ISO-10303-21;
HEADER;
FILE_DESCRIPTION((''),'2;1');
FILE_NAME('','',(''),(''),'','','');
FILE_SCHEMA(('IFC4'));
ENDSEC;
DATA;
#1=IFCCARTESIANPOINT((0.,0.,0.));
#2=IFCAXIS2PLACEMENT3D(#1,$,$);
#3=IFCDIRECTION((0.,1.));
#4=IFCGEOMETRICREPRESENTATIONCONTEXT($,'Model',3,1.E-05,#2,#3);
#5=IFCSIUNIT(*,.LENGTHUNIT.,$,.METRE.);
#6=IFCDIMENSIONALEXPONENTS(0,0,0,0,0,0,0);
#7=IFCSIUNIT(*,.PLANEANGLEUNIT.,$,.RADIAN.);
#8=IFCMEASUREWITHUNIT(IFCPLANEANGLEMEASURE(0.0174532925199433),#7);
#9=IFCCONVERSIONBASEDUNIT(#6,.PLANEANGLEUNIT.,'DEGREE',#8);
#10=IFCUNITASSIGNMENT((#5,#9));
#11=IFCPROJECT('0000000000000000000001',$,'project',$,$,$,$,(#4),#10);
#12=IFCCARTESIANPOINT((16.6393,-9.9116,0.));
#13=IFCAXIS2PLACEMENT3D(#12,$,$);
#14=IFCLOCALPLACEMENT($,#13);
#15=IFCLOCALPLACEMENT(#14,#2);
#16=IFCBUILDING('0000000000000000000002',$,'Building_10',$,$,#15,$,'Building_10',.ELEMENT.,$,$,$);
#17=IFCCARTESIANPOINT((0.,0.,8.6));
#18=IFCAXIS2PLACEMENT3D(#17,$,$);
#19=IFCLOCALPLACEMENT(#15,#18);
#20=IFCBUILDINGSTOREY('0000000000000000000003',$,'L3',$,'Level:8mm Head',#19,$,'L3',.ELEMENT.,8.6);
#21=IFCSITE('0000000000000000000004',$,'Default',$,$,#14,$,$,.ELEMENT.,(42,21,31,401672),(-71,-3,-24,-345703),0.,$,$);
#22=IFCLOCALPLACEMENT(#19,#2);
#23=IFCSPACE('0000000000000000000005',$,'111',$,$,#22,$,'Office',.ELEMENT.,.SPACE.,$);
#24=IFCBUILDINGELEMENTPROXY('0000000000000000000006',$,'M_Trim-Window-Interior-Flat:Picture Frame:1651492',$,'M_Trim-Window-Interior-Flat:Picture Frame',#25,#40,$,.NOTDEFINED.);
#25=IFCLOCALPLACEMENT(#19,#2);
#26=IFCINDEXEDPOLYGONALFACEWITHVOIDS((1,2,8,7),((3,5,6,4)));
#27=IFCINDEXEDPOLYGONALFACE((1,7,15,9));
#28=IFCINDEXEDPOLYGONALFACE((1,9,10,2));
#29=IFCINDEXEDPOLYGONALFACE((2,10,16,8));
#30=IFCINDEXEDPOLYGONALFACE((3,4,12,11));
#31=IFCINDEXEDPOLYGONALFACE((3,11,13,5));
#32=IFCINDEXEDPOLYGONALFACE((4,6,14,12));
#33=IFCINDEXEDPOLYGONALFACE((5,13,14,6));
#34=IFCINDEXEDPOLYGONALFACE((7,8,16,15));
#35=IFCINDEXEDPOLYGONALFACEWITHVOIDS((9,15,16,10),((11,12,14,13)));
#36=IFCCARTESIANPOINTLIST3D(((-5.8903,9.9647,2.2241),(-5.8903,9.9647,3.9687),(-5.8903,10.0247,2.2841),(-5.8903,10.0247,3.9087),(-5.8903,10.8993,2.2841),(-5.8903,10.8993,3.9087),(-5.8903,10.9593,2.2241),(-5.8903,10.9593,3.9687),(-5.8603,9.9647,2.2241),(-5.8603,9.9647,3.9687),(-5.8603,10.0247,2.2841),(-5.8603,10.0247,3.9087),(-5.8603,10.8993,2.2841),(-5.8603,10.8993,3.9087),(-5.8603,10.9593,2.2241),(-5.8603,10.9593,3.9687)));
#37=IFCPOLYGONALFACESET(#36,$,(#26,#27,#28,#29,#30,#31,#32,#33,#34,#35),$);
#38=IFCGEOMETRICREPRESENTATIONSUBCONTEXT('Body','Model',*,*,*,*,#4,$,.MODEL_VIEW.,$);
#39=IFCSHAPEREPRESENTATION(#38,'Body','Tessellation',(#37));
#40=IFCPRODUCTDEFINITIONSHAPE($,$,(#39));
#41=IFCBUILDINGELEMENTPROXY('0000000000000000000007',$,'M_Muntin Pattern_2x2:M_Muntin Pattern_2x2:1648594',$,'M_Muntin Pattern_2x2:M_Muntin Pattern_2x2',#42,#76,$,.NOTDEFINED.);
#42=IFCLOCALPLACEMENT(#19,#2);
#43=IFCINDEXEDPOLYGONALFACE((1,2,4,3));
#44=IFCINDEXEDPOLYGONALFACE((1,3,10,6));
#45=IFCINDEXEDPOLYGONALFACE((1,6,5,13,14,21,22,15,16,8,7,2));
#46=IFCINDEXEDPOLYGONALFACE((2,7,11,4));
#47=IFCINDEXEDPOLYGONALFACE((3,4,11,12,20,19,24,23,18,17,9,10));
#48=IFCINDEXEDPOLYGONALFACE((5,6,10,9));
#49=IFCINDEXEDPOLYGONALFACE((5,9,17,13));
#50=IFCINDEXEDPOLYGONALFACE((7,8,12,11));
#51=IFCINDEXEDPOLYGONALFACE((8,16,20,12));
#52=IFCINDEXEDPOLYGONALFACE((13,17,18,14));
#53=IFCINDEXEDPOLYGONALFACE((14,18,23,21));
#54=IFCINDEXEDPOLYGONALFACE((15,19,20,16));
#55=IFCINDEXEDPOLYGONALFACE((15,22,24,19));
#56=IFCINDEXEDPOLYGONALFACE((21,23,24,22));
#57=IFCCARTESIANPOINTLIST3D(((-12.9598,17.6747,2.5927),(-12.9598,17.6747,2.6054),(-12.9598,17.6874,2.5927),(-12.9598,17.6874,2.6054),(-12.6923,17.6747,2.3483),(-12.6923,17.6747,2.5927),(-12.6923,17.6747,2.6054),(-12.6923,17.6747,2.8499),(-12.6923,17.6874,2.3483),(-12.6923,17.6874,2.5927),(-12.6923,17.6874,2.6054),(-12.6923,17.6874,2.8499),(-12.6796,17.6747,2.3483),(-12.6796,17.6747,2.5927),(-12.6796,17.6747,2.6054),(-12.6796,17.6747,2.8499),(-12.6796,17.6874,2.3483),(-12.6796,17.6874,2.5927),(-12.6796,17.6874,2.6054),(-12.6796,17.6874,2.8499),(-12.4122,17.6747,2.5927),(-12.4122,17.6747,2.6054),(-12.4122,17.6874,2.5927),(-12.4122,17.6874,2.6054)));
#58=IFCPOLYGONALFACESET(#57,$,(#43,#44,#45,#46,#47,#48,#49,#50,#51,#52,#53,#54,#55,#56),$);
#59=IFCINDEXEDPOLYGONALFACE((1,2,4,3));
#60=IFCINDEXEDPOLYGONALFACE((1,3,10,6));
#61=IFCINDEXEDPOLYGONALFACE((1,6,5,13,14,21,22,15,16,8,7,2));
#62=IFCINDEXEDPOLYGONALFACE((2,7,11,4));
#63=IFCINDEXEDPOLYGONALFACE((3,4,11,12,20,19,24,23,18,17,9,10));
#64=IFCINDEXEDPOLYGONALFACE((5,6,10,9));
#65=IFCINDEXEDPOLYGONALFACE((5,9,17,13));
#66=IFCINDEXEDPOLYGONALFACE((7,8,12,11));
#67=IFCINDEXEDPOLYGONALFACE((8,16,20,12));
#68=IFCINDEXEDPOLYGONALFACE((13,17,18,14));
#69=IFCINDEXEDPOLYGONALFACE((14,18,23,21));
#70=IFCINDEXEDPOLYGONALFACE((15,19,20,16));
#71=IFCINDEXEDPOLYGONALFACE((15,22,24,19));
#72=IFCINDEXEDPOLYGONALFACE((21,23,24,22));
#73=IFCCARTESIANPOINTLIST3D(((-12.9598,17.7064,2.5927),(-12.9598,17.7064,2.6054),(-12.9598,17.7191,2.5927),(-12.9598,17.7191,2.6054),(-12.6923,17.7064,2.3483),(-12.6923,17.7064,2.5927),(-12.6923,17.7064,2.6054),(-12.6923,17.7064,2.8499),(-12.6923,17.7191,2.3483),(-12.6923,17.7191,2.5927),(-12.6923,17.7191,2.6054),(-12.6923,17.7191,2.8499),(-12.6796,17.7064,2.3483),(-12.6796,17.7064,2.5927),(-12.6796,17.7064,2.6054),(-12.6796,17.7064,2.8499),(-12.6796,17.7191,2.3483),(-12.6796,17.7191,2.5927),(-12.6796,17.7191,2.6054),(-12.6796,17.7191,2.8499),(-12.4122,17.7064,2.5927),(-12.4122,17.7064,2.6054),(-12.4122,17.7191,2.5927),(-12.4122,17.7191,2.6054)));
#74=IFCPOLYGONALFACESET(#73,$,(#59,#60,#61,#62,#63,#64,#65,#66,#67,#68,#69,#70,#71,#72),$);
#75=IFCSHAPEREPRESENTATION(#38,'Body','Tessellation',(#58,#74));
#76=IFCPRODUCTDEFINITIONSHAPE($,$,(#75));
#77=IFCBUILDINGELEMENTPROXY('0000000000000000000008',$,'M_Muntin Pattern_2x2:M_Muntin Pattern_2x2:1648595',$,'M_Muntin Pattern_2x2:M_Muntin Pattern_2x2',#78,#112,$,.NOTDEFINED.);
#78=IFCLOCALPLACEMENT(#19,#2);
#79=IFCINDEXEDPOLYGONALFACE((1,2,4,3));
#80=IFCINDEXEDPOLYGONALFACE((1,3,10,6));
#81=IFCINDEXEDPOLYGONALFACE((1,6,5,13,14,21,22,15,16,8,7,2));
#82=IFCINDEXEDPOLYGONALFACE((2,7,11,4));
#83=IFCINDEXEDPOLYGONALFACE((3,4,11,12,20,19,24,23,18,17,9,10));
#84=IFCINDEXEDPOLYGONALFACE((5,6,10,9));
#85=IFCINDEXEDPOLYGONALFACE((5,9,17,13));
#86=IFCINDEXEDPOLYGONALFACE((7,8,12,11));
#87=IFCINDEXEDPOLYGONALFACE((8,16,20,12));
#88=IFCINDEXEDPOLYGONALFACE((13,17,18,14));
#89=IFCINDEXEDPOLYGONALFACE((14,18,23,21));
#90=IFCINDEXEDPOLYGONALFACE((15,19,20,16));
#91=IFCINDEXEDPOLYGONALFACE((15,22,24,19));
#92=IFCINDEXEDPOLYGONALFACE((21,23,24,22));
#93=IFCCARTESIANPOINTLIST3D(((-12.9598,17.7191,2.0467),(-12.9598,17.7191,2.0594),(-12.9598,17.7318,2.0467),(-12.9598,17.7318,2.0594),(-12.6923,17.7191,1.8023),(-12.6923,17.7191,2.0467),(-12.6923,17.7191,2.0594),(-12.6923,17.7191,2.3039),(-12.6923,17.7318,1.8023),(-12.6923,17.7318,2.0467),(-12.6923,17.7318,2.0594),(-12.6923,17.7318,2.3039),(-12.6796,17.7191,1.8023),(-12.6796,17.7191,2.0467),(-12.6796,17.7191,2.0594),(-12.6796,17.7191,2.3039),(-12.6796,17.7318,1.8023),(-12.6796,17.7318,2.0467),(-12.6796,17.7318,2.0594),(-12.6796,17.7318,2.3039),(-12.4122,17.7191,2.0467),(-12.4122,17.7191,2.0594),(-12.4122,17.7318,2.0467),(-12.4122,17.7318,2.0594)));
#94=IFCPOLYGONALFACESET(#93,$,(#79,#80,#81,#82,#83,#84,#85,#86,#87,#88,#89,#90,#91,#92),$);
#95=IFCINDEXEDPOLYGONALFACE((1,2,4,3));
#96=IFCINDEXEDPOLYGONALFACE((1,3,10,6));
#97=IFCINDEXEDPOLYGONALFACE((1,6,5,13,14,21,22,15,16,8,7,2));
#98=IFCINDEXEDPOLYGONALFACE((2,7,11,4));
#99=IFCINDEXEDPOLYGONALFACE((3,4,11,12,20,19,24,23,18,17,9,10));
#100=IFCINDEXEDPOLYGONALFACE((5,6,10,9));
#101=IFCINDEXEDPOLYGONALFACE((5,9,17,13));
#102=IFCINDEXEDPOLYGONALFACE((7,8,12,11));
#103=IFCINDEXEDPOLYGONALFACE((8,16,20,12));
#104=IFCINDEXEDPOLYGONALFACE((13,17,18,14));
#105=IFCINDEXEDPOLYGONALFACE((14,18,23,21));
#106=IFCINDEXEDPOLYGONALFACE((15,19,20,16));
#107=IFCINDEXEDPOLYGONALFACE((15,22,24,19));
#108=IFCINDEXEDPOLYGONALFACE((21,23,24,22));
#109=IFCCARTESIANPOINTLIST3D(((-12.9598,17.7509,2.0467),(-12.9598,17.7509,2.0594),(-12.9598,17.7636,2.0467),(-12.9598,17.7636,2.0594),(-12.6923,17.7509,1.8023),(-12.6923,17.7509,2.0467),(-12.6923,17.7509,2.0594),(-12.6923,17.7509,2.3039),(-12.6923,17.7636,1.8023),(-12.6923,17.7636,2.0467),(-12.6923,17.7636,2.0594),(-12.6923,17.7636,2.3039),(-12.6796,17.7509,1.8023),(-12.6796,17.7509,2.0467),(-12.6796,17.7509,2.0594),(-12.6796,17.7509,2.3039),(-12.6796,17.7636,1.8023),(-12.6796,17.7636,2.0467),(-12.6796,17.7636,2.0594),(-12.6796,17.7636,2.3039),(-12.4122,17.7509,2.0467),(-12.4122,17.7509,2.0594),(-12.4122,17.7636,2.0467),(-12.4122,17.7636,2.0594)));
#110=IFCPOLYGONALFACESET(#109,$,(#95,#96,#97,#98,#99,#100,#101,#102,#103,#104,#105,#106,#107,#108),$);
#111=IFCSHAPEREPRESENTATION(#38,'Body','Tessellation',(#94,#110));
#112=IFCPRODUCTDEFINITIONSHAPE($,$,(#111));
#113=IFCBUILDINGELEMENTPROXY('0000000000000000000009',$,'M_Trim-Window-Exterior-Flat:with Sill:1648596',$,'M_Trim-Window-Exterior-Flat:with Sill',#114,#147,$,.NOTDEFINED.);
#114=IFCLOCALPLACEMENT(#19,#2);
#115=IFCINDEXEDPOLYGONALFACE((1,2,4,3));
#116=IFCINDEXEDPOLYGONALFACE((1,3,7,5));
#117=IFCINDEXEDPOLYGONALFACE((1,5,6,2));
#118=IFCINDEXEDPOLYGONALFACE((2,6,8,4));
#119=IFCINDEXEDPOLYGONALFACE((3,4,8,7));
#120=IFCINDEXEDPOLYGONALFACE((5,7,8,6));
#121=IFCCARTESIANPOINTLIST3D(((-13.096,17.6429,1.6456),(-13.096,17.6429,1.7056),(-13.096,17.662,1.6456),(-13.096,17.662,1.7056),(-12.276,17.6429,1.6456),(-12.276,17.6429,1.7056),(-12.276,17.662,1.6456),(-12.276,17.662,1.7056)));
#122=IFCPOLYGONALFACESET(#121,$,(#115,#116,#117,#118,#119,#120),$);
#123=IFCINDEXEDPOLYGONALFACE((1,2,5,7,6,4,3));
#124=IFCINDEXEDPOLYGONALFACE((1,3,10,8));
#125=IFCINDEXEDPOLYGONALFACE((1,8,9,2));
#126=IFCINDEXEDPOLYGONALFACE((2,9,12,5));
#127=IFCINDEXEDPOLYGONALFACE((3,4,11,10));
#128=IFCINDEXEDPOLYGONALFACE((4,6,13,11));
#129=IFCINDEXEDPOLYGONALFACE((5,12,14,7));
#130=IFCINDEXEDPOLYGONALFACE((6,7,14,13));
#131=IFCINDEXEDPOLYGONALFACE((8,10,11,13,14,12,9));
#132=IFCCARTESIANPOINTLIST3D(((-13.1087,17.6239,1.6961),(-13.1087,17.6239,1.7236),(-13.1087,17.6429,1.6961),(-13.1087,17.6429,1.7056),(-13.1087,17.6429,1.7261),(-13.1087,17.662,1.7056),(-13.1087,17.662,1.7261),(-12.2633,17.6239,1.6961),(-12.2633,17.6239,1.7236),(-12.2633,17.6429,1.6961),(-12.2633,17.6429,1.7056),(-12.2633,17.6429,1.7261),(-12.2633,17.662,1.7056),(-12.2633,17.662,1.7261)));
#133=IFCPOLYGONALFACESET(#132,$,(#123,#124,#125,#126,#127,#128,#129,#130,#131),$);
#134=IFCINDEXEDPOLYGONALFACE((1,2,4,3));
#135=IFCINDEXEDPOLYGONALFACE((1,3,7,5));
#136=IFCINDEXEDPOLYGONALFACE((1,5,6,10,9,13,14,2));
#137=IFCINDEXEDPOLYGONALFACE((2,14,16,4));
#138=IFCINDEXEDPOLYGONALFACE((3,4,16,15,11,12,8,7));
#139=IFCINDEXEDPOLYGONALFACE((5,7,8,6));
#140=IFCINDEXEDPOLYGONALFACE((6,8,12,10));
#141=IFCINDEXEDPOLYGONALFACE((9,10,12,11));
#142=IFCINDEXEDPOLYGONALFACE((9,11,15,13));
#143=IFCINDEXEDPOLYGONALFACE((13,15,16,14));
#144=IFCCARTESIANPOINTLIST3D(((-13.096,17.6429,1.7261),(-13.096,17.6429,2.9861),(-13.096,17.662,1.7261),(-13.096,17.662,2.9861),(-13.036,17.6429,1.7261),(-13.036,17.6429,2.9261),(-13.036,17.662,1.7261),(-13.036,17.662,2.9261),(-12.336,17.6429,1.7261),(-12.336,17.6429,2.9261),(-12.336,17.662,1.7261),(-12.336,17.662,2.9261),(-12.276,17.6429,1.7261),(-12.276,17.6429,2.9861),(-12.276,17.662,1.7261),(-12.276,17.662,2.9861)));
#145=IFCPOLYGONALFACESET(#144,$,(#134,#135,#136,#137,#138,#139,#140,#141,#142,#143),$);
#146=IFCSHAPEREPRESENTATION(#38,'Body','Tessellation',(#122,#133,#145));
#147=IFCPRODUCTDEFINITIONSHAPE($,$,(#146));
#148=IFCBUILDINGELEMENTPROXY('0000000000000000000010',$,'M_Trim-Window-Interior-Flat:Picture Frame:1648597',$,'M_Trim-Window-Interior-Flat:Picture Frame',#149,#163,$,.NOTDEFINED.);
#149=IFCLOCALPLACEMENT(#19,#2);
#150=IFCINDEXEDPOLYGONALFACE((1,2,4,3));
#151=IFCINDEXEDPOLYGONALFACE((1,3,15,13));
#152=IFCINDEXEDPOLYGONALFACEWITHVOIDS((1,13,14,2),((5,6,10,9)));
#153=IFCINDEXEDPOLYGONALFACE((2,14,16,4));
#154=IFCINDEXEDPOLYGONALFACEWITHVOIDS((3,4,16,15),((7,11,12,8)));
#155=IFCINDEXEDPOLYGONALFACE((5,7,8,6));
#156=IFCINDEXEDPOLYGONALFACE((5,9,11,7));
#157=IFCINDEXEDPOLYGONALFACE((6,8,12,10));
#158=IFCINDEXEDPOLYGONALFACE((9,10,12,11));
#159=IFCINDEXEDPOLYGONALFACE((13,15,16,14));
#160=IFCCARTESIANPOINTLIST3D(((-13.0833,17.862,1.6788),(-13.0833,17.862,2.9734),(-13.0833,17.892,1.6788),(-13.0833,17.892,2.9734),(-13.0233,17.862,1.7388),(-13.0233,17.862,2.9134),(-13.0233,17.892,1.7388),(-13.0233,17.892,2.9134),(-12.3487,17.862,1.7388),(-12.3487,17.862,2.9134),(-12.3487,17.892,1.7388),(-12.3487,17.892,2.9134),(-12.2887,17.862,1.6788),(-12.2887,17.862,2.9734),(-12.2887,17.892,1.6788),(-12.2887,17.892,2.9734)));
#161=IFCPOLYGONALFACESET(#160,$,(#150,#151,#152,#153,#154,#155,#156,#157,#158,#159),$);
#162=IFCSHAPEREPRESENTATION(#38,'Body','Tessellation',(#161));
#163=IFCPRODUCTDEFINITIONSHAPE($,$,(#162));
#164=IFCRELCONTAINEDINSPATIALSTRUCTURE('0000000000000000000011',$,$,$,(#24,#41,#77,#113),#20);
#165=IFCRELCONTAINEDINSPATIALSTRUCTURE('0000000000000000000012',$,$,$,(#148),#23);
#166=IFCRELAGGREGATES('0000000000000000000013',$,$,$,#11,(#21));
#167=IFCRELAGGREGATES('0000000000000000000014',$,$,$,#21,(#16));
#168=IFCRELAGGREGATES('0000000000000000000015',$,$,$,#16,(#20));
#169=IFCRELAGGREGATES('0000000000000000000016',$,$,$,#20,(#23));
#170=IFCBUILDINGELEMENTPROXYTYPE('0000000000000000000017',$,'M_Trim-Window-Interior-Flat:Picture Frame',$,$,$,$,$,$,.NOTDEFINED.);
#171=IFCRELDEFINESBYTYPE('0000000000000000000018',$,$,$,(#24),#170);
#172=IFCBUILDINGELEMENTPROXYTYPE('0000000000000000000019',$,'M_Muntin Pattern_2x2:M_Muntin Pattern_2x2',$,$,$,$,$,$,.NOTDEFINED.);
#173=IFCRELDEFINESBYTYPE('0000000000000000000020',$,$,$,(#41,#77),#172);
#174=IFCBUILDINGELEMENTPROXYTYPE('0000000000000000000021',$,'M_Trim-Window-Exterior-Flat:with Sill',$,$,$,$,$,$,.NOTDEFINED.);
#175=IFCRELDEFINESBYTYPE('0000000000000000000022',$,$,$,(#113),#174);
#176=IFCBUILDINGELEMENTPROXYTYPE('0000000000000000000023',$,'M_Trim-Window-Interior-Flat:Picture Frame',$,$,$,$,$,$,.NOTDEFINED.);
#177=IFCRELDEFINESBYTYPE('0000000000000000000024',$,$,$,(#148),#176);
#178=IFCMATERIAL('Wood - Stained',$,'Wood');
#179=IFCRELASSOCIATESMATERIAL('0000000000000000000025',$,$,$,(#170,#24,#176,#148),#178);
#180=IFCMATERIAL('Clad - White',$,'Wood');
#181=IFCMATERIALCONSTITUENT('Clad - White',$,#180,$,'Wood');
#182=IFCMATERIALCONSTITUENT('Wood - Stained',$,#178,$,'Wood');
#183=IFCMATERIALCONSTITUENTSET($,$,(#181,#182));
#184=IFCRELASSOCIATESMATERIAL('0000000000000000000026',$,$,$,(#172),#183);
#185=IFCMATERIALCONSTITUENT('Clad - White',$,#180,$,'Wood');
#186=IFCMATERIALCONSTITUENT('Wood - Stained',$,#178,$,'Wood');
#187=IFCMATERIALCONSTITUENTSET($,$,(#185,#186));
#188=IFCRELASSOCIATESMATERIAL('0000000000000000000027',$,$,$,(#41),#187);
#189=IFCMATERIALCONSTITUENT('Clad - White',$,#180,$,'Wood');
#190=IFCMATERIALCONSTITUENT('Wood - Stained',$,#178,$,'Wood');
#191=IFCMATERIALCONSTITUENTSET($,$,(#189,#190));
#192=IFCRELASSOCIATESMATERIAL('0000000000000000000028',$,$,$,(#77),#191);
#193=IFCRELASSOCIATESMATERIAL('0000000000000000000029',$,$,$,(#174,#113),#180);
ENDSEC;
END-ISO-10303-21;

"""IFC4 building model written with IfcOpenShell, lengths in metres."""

from ifc_helpers import new_model, entity, si_unit, converted_unit, direction, frame, origin, place, context, subcontext, project, spatial, indexed_curve, outline, extrude, source, transform, mapped, material, constituent, constituent_set, type_object, type_shapes, element, save


model = new_model("IFC4")

# Units and contexts
model_context = context("Model", 3, precision=1e-05, world=origin(), true_north=direction((0.0, 1.0)))
body_context = subcontext(model_context, "Body", "Model", "MODEL_VIEW")
ifc_project = project(units=[si_unit("LENGTHUNIT", "METRE"), converted_unit("PLANEANGLEUNIT", "DEGREE", entity("IfcPlaneAngleMeasure", 0.0174532925199433), si_unit("PLANEANGLEUNIT", "RADIAN"), dimensions=[0, 0, 0, 0, 0, 0, 0])], contexts=[model_context])

# Site, building, storey
site_placement = place(None, frame((16.6393, -9.9116, 0.0)))
site = spatial("IfcSite", under=ifc_project, at=site_placement, Name="Default", CompositionType="ELEMENT", RefLatitude=(42, 21, 31, 401672), RefLongitude=(-71, -3, -24, -345703), RefElevation=0.0)
building_placement = place(site_placement, origin())
building = spatial("IfcBuilding", under=site, at=building_placement, Name="Building_10", LongName="Building_10", CompositionType="ELEMENT")
storey_placement = place(building_placement, frame((0.0, 0.0, 8.6)))
storey = spatial("IfcBuildingStorey", under=building, at=storey_placement, Name="L3", ObjectType="Level:8mm Head", LongName="L3", CompositionType="ELEMENT", Elevation=8.6)

# Building element proxies
ifc_material_1 = material(Name="Clad - White", Category="Wood")
ifc_material_2 = material(Name="Wood - Stained", Category="Wood")
building_element_proxy_type_1 = type_object("IfcBuildingElementProxyType", Name="M_Trim-Window-Interior-Flat:Picture Frame", PredefinedType="NOTDEFINED", material=ifc_material_2)
shared_shape_1 = source(origin(), body_context, "Body", "SweptSolid", [
    extrude(outline(indexed_curve([(-0.4973, -0.8723), (0.4973, -0.8723), (0.4973, 0.8723), (-0.4973, 0.8723), (-0.4973, -0.8723)], self_intersect=False), holes=[indexed_curve([(-0.4373, -0.8123), (-0.4373, 0.8123), (0.4373, 0.8123), (0.4373, -0.8123), (-0.4373, -0.8123)], self_intersect=False)]), frame((0.0, -0.825, 0.0), z_axis=(0.0, 0.0, 1.0), x_axis=(-1.0, 0.0, 0.0)), (0.0, 0.0, 1.0), 0.03),
])
type_shapes(building_element_proxy_type_1, [shared_shape_1])
for number, where, z_axis, x_axis, name in (
    (1, (-5.8603, 10.462, 3.9214), (-1.0, 0.0, 0.0), (0.0, -1.0, 0.0), "M_Trim-Window-Interior-Flat:Picture Frame:1651492"),
):
    element("IfcBuildingElementProxy", number, at=place(storey_placement, frame(where, z_axis=z_axis, x_axis=x_axis)), inside=storey, type_object=building_element_proxy_type_1, material=ifc_material_2, Name=name, ObjectType="M_Trim-Window-Interior-Flat:Picture Frame", PredefinedType="NOTDEFINED", context=body_context, shape_type="MappedRepresentation", body=[
        mapped(shared_shape_1, transform((0.0, 0.0, 0.0), scale=1.0)),
    ])
ifc_constituent_1 = constituent(ifc_material_1, Name="Clad - White", Category="Wood")
ifc_constituent_2 = constituent(ifc_material_2, Name="Wood - Stained", Category="Wood")
ifc_constituent_set_1 = constituent_set(constituents=[ifc_constituent_1, ifc_constituent_2])
ifc_constituent_3 = constituent(ifc_material_1, Name="Clad - White", Category="Wood")
ifc_constituent_4 = constituent(ifc_material_2, Name="Wood - Stained", Category="Wood")
ifc_constituent_set_2 = constituent_set(constituents=[ifc_constituent_3, ifc_constituent_4])
building_element_proxy_type_2 = type_object("IfcBuildingElementProxyType", Name="M_Muntin Pattern_2x2:M_Muntin Pattern_2x2", PredefinedType="NOTDEFINED", material=ifc_constituent_set_2)
shared_shape_2 = source(origin(), body_context, "Body", "SweptSolid", [
    extrude(outline(indexed_curve([(0.0064, -0.0064), (0.2508, -0.0064), (0.2508, 0.0063), (0.0064, 0.0063), (0.0064, 0.2738), (-0.0063, 0.2738), (-0.0063, 0.0063), (-0.2508, 0.0063), (-0.2508, -0.0064), (-0.0063, -0.0064), (-0.0063, -0.2738), (0.0064, -0.2738), (0.0064, -0.0064)], self_intersect=False)), frame((0.0, 0.0095, 0.2508), z_axis=(0.0, 1.0, 0.0), x_axis=(0.0, 0.0, 1.0)), (0.0, 0.0, 1.0), 0.0127),
    extrude(outline(indexed_curve([(0.0064, -0.0064), (0.2508, -0.0064), (0.2508, 0.0063), (0.0064, 0.0063), (0.0064, 0.2738), (-0.0063, 0.2738), (-0.0063, 0.0063), (-0.2508, 0.0063), (-0.2508, -0.0064), (-0.0063, -0.0064), (-0.0063, -0.2738), (0.0064, -0.2738), (0.0064, -0.0064)], self_intersect=False)), frame((0.0, -0.0222, 0.2508), z_axis=(0.0, 1.0, 0.0), x_axis=(0.0, 0.0, 1.0)), (0.0, 0.0, 1.0), 0.0127),
])
type_shapes(building_element_proxy_type_2, [shared_shape_2])
proxy_1_placement = place(storey_placement, frame((-12.686, 17.6969, 2.3483), z_axis=(0.0, 0.0, 1.0), x_axis=(-1.0, 0.0, 0.0)))
element("IfcBuildingElementProxy", 2, at=proxy_1_placement, inside=storey, type_object=building_element_proxy_type_2, material=ifc_constituent_set_1, Name="M_Muntin Pattern_2x2:M_Muntin Pattern_2x2:1648594", ObjectType="M_Muntin Pattern_2x2:M_Muntin Pattern_2x2", PredefinedType="NOTDEFINED", context=body_context, shape_type="MappedRepresentation", body=[
    mapped(shared_shape_2, transform((0.0, 0.0, 0.0), scale=1.0)),
])
ifc_constituent_5 = constituent(ifc_material_1, Name="Clad - White", Category="Wood")
ifc_constituent_6 = constituent(ifc_material_2, Name="Wood - Stained", Category="Wood")
ifc_constituent_set_3 = constituent_set(constituents=[ifc_constituent_5, ifc_constituent_6])
proxy_2_placement = place(storey_placement, frame((-12.686, 17.7413, 1.8023), z_axis=(0.0, 0.0, 1.0), x_axis=(-1.0, 0.0, 0.0)))
element("IfcBuildingElementProxy", 3, at=proxy_2_placement, inside=storey, type_object=building_element_proxy_type_2, material=ifc_constituent_set_3, Name="M_Muntin Pattern_2x2:M_Muntin Pattern_2x2:1648595", ObjectType="M_Muntin Pattern_2x2:M_Muntin Pattern_2x2", PredefinedType="NOTDEFINED", context=body_context, shape_type="MappedRepresentation", body=[
    mapped(shared_shape_2, transform((0.0, 0.0, 0.0), scale=1.0)),
])
building_element_proxy_type_3 = type_object("IfcBuildingElementProxyType", Name="M_Trim-Window-Exterior-Flat:with Sill", PredefinedType="NOTDEFINED", material=ifc_material_1)
shared_shape_3 = source(origin(), body_context, "Body", "SweptSolid", [
    extrude(outline(indexed_curve([(-0.41, -0.03), (0.41, -0.03), (0.41, 0.03), (-0.41, 0.03), (-0.41, -0.03)], self_intersect=False)), frame((0.0, -1.2504, 0.0), z_axis=(0.0, 0.0, 1.0), x_axis=(-1.0, 0.0, 0.0)), (0.0, 0.0, 1.0), 0.0191),
    extrude(outline(indexed_curve([(-0.019, -0.0152), (0.0, -0.0152), (0.0, -0.0057), (0.019, -0.0057), (0.019, 0.0148), (0.0, 0.0148), (-0.019, 0.0123), (-0.019, -0.0152)], self_intersect=False)), frame((-0.4227, -1.2148, 0.019), z_axis=(1.0, 0.0, 0.0), x_axis=(0.0, 0.0, -1.0)), (0.0, 0.0, 1.0), 0.8454),
    extrude(outline(indexed_curve([(-0.645, -0.41), (0.615, -0.41), (0.615, -0.35), (-0.585, -0.35), (-0.585, 0.35), (0.615, 0.35), (0.615, 0.41), (-0.645, 0.41), (-0.645, -0.41)], self_intersect=False)), frame((0.0, -0.585, 0.0), z_axis=(0.0, 0.0, 1.0), x_axis=(0.0, -1.0, 0.0)), (0.0, 0.0, 1.0), 0.0191),
])
type_shapes(building_element_proxy_type_3, [shared_shape_3])
proxy_3_placement = place(storey_placement, frame((-12.686, 17.662, 2.9261), z_axis=(0.0, -1.0, 0.0), x_axis=(1.0, 0.0, 0.0)))
element("IfcBuildingElementProxy", 4, at=proxy_3_placement, inside=storey, type_object=building_element_proxy_type_3, material=ifc_material_1, Name="M_Trim-Window-Exterior-Flat:with Sill:1648596", ObjectType="M_Trim-Window-Exterior-Flat:with Sill", PredefinedType="NOTDEFINED", context=body_context, shape_type="MappedRepresentation", body=[
    mapped(shared_shape_3, transform((0.0, 0.0, 0.0), scale=1.0)),
])

# Shared definitions
space_placement = place(storey_placement, origin())
space = spatial("IfcSpace", under=storey, at=space_placement, Name="111", LongName="Office", CompositionType="ELEMENT", PredefinedType="SPACE")

# Building element proxy
building_element_proxy_type_4 = type_object("IfcBuildingElementProxyType", Name="M_Trim-Window-Interior-Flat:Picture Frame", PredefinedType="NOTDEFINED", material=ifc_material_2)
shared_shape_4 = source(origin(), body_context, "Body", "SweptSolid", [
    extrude(outline(indexed_curve([(-0.3973, -0.6473), (0.3973, -0.6473), (0.3973, 0.6473), (-0.3973, 0.6473), (-0.3973, -0.6473)], self_intersect=False), holes=[indexed_curve([(-0.3373, -0.5873), (-0.3373, 0.5873), (0.3373, 0.5873), (0.3373, -0.5873), (-0.3373, -0.5873)], self_intersect=False)]), frame((0.0, -0.6, 0.0), z_axis=(0.0, 0.0, 1.0), x_axis=(-1.0, 0.0, 0.0)), (0.0, 0.0, 1.0), 0.03),
])
type_shapes(building_element_proxy_type_4, [shared_shape_4])
proxy_4_placement = place(space_placement, frame((-12.686, 17.862, 2.9261), z_axis=(0.0, 1.0, 0.0), x_axis=(-1.0, 0.0, 0.0)))
element("IfcBuildingElementProxy", 5, at=proxy_4_placement, inside=space, type_object=building_element_proxy_type_4, material=ifc_material_2, Name="M_Trim-Window-Interior-Flat:Picture Frame:1648597", ObjectType="M_Trim-Window-Interior-Flat:Picture Frame", PredefinedType="NOTDEFINED", context=body_context, shape_type="MappedRepresentation", body=[
    mapped(shared_shape_4, transform((0.0, 0.0, 0.0), scale=1.0)),
])

save(model, "model.ifc")
